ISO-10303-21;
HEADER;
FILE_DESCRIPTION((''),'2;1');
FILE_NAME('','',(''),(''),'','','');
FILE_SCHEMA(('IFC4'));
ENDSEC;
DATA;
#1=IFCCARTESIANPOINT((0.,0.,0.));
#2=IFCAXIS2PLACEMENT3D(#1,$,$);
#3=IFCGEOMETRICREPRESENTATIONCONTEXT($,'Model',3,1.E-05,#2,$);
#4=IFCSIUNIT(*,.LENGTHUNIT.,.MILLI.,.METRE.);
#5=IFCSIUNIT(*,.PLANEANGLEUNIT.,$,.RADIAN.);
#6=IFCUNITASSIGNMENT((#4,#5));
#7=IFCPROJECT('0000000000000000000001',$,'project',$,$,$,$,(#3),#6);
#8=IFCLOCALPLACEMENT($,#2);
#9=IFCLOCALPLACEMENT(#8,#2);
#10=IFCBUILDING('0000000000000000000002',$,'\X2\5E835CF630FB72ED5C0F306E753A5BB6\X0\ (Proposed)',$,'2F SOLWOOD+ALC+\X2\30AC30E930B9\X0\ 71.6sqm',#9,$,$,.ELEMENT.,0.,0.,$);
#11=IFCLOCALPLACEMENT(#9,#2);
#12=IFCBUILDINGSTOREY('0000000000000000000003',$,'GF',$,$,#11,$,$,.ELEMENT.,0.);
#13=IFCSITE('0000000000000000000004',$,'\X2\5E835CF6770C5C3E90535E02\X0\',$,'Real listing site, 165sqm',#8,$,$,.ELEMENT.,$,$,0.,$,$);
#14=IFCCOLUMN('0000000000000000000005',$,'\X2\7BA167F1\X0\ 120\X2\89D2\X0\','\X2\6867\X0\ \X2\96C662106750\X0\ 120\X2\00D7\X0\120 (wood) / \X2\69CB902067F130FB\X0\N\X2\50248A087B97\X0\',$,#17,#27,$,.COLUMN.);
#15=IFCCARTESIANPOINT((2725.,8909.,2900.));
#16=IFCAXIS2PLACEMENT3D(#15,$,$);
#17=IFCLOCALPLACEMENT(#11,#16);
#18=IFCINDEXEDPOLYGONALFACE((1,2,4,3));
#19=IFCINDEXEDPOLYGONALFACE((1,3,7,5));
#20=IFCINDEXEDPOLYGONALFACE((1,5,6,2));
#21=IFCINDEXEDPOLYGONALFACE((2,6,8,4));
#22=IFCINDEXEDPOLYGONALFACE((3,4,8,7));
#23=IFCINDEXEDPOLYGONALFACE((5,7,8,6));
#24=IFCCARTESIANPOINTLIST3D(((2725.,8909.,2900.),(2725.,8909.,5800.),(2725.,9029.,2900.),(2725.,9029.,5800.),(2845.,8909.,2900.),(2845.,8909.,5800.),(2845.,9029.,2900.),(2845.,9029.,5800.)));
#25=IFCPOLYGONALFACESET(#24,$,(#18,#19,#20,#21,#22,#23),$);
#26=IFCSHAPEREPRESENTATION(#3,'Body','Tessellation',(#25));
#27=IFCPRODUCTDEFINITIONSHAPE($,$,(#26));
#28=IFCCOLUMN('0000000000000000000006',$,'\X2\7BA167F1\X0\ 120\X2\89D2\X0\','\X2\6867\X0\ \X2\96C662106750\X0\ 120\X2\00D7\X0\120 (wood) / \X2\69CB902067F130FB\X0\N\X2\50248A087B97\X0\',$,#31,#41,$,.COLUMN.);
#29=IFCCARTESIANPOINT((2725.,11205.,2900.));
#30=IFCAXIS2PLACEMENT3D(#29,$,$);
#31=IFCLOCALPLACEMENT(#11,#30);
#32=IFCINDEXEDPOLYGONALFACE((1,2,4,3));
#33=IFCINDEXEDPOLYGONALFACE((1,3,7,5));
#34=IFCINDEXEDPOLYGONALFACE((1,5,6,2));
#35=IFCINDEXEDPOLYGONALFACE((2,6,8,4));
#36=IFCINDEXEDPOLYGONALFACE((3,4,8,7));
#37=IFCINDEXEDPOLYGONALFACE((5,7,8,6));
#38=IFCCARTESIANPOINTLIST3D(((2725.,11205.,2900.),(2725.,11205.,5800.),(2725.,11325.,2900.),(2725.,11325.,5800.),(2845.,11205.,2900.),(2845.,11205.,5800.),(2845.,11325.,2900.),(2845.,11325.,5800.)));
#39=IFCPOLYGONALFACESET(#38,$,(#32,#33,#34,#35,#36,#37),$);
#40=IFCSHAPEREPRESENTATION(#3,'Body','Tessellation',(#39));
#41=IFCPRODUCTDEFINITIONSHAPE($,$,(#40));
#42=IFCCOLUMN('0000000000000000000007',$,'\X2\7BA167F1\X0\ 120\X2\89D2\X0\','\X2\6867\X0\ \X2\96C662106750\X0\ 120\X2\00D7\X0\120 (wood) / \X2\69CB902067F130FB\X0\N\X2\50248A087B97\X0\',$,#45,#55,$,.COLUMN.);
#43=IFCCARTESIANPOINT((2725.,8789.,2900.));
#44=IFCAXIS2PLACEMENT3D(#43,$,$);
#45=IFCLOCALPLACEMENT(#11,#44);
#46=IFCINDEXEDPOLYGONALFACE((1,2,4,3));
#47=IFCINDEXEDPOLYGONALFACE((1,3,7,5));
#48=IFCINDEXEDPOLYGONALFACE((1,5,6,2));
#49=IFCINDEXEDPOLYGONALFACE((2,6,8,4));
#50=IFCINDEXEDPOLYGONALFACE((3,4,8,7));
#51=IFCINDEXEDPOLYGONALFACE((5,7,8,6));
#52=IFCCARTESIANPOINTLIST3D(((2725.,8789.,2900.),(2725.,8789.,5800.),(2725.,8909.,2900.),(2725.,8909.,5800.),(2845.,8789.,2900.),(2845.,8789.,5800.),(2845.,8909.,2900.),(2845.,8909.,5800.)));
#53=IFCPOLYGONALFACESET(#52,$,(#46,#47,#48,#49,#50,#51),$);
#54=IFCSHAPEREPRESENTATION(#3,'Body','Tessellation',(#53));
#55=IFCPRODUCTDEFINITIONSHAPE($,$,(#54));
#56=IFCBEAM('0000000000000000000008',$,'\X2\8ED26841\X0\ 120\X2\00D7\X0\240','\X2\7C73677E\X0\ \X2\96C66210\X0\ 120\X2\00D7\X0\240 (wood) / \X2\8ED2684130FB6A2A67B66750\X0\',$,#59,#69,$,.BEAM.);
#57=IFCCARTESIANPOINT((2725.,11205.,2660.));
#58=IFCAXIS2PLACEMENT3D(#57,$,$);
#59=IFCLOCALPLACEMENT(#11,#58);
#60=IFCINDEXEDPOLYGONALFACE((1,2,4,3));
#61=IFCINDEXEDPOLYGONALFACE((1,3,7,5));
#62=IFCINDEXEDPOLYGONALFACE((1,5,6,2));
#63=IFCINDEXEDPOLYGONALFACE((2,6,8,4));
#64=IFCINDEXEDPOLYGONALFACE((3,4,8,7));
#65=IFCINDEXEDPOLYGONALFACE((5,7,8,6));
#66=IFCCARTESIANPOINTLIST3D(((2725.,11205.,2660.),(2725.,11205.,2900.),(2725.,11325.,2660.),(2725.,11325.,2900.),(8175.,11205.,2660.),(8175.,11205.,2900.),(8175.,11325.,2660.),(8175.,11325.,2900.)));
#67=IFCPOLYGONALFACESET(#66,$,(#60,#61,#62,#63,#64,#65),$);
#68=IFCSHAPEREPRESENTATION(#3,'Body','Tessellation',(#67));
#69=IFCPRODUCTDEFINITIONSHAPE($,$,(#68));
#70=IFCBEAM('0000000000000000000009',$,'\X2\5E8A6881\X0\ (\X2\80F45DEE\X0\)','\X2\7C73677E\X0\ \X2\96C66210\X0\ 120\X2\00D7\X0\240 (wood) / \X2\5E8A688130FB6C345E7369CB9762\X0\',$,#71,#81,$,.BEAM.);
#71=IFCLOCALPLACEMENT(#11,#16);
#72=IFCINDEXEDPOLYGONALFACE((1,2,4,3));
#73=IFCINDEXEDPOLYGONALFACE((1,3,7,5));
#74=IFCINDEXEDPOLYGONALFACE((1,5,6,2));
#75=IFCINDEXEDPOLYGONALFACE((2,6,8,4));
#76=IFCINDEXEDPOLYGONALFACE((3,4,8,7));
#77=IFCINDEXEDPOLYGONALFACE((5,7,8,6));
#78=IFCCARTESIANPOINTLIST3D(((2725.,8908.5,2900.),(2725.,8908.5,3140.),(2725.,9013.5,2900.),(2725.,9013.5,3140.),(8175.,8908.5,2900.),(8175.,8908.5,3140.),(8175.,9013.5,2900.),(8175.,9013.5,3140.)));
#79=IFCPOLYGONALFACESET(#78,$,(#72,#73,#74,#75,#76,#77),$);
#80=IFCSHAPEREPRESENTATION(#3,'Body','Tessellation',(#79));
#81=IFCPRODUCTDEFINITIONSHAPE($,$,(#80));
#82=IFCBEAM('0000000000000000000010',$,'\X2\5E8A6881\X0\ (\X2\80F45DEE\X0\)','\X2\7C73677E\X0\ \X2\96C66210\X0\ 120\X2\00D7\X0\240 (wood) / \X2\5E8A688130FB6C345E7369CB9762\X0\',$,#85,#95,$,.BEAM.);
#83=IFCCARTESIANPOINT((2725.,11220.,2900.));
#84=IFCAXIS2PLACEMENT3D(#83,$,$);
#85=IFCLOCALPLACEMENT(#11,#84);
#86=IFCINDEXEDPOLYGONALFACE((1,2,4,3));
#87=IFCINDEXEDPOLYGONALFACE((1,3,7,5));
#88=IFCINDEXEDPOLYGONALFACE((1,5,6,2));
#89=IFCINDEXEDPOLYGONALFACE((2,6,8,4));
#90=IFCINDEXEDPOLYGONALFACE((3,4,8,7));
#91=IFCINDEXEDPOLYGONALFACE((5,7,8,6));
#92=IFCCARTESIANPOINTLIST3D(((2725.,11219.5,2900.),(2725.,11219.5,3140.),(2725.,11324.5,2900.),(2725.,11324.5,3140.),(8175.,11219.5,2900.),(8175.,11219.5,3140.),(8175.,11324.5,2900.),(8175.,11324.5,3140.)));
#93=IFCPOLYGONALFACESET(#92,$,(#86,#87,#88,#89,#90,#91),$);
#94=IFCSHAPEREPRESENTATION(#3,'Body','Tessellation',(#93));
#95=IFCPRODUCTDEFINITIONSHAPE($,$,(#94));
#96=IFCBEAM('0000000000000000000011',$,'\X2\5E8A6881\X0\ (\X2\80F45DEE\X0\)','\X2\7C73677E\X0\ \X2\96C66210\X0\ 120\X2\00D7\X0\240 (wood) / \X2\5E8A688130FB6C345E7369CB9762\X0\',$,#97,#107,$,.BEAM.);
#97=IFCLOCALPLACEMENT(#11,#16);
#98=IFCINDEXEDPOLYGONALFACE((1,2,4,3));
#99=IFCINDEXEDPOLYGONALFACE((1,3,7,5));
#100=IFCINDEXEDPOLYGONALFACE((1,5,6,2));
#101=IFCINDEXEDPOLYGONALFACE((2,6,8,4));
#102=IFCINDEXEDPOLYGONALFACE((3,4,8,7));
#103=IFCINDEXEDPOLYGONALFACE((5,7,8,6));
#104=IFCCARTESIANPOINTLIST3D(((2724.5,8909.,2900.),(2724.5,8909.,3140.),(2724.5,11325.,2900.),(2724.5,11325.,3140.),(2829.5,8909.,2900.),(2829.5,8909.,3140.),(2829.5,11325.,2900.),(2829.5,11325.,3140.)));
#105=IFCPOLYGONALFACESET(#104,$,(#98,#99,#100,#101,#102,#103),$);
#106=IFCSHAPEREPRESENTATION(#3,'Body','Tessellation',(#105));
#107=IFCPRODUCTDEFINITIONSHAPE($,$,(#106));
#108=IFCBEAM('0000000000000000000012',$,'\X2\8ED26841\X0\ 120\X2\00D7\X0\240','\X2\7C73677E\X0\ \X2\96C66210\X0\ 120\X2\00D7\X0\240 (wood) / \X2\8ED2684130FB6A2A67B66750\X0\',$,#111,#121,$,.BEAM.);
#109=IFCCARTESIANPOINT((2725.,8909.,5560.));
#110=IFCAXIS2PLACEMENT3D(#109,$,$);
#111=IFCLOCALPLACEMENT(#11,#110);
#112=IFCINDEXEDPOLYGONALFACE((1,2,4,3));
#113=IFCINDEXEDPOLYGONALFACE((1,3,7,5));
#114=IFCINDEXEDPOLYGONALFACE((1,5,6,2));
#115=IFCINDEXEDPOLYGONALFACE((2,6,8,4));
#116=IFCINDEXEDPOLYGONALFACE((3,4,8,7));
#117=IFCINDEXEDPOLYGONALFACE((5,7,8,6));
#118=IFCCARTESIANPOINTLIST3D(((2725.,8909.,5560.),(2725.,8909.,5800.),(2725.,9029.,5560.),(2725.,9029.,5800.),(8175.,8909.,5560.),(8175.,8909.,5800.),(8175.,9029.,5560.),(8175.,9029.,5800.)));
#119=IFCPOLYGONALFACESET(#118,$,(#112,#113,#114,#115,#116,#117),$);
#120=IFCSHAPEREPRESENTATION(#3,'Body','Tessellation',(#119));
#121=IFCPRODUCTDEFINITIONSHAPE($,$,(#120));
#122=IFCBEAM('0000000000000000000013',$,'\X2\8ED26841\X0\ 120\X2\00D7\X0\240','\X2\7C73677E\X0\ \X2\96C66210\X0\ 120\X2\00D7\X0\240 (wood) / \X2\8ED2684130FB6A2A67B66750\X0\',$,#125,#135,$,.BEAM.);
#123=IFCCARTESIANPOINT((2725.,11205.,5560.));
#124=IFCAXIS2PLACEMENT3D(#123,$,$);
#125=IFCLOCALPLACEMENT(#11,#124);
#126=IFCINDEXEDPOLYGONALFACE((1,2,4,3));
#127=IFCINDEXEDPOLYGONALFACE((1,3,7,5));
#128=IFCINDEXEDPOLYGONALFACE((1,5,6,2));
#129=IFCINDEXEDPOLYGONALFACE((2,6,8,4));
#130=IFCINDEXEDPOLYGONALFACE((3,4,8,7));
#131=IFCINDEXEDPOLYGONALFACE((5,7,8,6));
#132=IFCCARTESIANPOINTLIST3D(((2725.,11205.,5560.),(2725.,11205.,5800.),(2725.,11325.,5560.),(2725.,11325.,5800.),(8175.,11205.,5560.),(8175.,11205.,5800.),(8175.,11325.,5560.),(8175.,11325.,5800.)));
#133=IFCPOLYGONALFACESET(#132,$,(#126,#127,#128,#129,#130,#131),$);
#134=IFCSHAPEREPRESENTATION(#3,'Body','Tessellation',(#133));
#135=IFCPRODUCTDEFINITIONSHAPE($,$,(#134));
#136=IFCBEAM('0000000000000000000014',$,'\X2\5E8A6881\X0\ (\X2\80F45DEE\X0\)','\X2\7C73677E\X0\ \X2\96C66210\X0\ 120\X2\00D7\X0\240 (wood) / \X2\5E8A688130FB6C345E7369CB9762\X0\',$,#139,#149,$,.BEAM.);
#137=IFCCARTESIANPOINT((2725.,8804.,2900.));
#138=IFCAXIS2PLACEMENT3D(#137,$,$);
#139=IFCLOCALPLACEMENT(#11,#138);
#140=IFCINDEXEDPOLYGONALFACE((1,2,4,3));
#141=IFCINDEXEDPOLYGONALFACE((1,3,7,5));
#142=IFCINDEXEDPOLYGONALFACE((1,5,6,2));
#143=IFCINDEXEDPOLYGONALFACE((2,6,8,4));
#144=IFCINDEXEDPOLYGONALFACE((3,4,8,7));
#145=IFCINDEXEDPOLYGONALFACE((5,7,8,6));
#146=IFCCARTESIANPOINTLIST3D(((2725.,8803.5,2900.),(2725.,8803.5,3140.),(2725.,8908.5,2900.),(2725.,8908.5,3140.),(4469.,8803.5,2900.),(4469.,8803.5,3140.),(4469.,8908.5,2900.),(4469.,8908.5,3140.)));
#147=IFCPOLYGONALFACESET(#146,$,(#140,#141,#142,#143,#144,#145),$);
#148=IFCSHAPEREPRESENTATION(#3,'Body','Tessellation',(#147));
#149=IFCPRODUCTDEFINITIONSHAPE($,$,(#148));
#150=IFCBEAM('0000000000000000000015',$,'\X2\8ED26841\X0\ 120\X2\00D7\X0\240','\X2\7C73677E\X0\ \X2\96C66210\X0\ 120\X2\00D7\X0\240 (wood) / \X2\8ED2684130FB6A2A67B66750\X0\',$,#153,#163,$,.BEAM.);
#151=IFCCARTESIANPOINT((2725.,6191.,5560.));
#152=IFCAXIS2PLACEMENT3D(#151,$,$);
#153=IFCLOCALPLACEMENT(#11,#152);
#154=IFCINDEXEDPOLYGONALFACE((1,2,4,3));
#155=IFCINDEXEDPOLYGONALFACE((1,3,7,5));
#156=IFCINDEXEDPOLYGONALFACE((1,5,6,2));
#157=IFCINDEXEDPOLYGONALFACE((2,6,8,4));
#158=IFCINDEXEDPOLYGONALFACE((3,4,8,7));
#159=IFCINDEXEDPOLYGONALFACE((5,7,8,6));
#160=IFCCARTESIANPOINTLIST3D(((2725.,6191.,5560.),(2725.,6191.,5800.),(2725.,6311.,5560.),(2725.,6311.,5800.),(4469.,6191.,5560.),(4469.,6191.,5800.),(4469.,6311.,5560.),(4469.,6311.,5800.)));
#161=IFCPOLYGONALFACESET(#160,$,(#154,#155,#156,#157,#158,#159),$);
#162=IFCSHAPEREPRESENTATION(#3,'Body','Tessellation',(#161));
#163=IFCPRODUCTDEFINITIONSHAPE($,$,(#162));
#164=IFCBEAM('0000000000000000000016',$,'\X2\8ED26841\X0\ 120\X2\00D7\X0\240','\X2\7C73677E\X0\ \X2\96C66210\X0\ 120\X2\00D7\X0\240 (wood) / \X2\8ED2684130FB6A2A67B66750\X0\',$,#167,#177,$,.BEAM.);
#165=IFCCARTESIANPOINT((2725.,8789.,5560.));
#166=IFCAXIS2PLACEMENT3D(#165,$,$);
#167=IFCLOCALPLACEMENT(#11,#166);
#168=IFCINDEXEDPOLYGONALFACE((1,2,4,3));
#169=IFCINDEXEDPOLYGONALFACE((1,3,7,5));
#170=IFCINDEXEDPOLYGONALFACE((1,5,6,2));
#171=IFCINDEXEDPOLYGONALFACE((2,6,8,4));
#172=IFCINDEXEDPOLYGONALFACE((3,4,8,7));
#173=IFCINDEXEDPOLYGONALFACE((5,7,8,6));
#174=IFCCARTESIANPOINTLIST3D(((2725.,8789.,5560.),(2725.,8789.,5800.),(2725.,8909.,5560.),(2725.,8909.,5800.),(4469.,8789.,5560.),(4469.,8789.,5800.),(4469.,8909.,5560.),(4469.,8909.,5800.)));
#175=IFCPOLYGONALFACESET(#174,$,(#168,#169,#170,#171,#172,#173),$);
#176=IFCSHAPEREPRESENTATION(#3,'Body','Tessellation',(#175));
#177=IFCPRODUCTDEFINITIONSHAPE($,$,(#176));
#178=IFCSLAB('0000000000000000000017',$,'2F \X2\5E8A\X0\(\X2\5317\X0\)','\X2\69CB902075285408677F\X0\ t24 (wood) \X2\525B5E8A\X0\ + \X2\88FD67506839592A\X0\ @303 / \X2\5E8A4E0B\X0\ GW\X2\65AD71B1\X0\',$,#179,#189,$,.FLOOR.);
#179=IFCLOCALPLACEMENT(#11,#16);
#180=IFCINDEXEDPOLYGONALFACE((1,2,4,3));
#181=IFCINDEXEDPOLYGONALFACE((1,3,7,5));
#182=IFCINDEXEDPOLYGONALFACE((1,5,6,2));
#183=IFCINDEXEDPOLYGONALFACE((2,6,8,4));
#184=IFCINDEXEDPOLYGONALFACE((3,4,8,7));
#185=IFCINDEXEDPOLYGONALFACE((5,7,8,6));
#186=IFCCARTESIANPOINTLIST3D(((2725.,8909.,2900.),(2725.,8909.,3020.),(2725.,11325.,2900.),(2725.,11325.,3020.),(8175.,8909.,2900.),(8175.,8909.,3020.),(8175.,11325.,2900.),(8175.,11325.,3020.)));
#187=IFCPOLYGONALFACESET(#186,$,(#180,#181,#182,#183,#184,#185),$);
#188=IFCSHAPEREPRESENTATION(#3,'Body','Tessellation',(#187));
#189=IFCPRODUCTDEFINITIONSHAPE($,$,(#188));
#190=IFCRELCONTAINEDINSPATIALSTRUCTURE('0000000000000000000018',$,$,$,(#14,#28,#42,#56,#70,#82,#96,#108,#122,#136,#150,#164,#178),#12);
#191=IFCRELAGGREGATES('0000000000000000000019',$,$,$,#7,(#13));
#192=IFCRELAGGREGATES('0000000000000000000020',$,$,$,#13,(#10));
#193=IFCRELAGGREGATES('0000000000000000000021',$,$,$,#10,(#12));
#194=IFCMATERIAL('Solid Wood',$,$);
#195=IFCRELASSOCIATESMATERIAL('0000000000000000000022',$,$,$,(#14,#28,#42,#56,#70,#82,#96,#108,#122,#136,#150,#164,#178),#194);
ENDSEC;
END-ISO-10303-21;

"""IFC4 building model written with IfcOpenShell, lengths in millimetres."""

from ifc_helpers import new_model, si_unit, frame, frame_2d, origin, place, context, project, spatial, rectangle, extrude, material, element, save


model = new_model("IFC4")

# Units and contexts
model_context = context("Model", 3, precision=1e-05, world=origin())
ifc_project = project(units=[si_unit("LENGTHUNIT", "METRE", prefix="MILLI"), si_unit("PLANEANGLEUNIT", "RADIAN")], contexts=[model_context])

# Site, building, storey
site_placement = place(None, origin())
site = spatial("IfcSite", under=ifc_project, at=site_placement, Name="広島県尾道市", ObjectType="Real listing site, 165sqm", CompositionType="ELEMENT", RefElevation=0.0)
building_placement = place(site_placement, origin())
building = spatial("IfcBuilding", under=site, at=building_placement, Name="広島・狭小の町家 (Proposed)", ObjectType="2F SOLWOOD+ALC+ガラス 71.6sqm", CompositionType="ELEMENT", ElevationOfRefHeight=0.0, ElevationOfTerrain=0.0)
storey_placement = place(building_placement, origin())
storey = spatial("IfcBuildingStorey", under=building, at=storey_placement, Name="GF", CompositionType="ELEMENT", Elevation=0.0)

# Columns
ifc_material_1 = material(Name="Solid Wood")
column_1_placement = place(storey_placement, frame((2725.0, 8909.0, 2900.0)))
element("IfcColumn", 1, at=column_1_placement, inside=storey, material=ifc_material_1, Name="管柱 120角", Description="桧 集成材 120×120 (wood) / 構造柱・N値計算", PredefinedType="COLUMN", context=model_context, shape_type="SweptSolid", body=[
    extrude(rectangle(XDim=120.0, YDim=120.0, at=frame_2d((60.0, 60.0))), frame((2725.0, 8909.0, 2900.0)), (0.0, 0.0, 1.0), 2900.0),
])
column_2_placement = place(storey_placement, frame((2725.0, 11205.0, 2900.0)))
element("IfcColumn", 2, at=column_2_placement, inside=storey, material=ifc_material_1, Name="管柱 120角", Description="桧 集成材 120×120 (wood) / 構造柱・N値計算", PredefinedType="COLUMN", context=model_context, shape_type="SweptSolid", body=[
    extrude(rectangle(XDim=120.0, YDim=120.0, at=frame_2d((60.0, 60.0))), frame((2725.0, 11205.0, 2900.0)), (0.0, 0.0, 1.0), 2900.0),
])
column_3_placement = place(storey_placement, frame((2725.0, 8789.0, 2900.0)))
element("IfcColumn", 3, at=column_3_placement, inside=storey, material=ifc_material_1, Name="管柱 120角", Description="桧 集成材 120×120 (wood) / 構造柱・N値計算", PredefinedType="COLUMN", context=model_context, shape_type="SweptSolid", body=[
    extrude(rectangle(XDim=120.0, YDim=120.0, at=frame_2d((60.0, 60.0))), frame((2725.0, 8789.0, 2900.0)), (0.0, 0.0, 1.0), 2900.0),
])

# Beams
beam_1_placement = place(storey_placement, frame((2725.0, 11205.0, 2660.0)))
element("IfcBeam", 4, at=beam_1_placement, inside=storey, material=ifc_material_1, Name="軒桁 120×240", Description="米松 集成 120×240 (wood) / 軒桁・横架材", PredefinedType="BEAM", context=model_context, shape_type="SweptSolid", body=[
    extrude(rectangle(XDim=5450.0, YDim=120.0, at=frame_2d((2725.0, 60.0))), frame((2725.0, 11205.0, 2660.0)), (0.0, 0.0, 1.0), 240.0),
])
beam_2_placement = place(storey_placement, frame((2725.0, 8909.0, 2900.0)))
element("IfcBeam", 5, at=beam_2_placement, inside=storey, material=ifc_material_1, Name="床梁 (胴差)", Description="米松 集成 120×240 (wood) / 床梁・水平構面", PredefinedType="BEAM", context=model_context, shape_type="SweptSolid", body=[
    extrude(rectangle(XDim=5450.0, YDim=105.0, at=frame_2d((2725.0, 52.0))), frame((2725.0, 8909.0, 2900.0)), (0.0, 0.0, 1.0), 240.0),
])
beam_3_placement = place(storey_placement, frame((2725.0, 11220.0, 2900.0)))
element("IfcBeam", 6, at=beam_3_placement, inside=storey, material=ifc_material_1, Name="床梁 (胴差)", Description="米松 集成 120×240 (wood) / 床梁・水平構面", PredefinedType="BEAM", context=model_context, shape_type="SweptSolid", body=[
    extrude(rectangle(XDim=5450.0, YDim=105.0, at=frame_2d((2725.0, 52.0))), frame((2725.0, 11220.0, 2900.0)), (0.0, 0.0, 1.0), 240.0),
])
beam_4_placement = place(storey_placement, frame((2725.0, 8909.0, 2900.0)))
element("IfcBeam", 7, at=beam_4_placement, inside=storey, material=ifc_material_1, Name="床梁 (胴差)", Description="米松 集成 120×240 (wood) / 床梁・水平構面", PredefinedType="BEAM", context=model_context, shape_type="SweptSolid", body=[
    extrude(rectangle(XDim=105.0, YDim=2416.0, at=frame_2d((52.0, 1208.0))), frame((2725.0, 8909.0, 2900.0)), (0.0, 0.0, 1.0), 240.0),
])
beam_5_placement = place(storey_placement, frame((2725.0, 8909.0, 5560.0)))
element("IfcBeam", 8, at=beam_5_placement, inside=storey, material=ifc_material_1, Name="軒桁 120×240", Description="米松 集成 120×240 (wood) / 軒桁・横架材", PredefinedType="BEAM", context=model_context, shape_type="SweptSolid", body=[
    extrude(rectangle(XDim=5450.0, YDim=120.0, at=frame_2d((2725.0, 60.0))), frame((2725.0, 8909.0, 5560.0)), (0.0, 0.0, 1.0), 240.0),
])
beam_6_placement = place(storey_placement, frame((2725.0, 11205.0, 5560.0)))
element("IfcBeam", 9, at=beam_6_placement, inside=storey, material=ifc_material_1, Name="軒桁 120×240", Description="米松 集成 120×240 (wood) / 軒桁・横架材", PredefinedType="BEAM", context=model_context, shape_type="SweptSolid", body=[
    extrude(rectangle(XDim=5450.0, YDim=120.0, at=frame_2d((2725.0, 60.0))), frame((2725.0, 11205.0, 5560.0)), (0.0, 0.0, 1.0), 240.0),
])
beam_7_placement = place(storey_placement, frame((2725.0, 8804.0, 2900.0)))
element("IfcBeam", 10, at=beam_7_placement, inside=storey, material=ifc_material_1, Name="床梁 (胴差)", Description="米松 集成 120×240 (wood) / 床梁・水平構面", PredefinedType="BEAM", context=model_context, shape_type="SweptSolid", body=[
    extrude(rectangle(XDim=1744.0, YDim=105.0, at=frame_2d((872.0, 52.0))), frame((2725.0, 8804.0, 2900.0)), (0.0, 0.0, 1.0), 240.0),
])
beam_8_placement = place(storey_placement, frame((2725.0, 6191.0, 5560.0)))
element("IfcBeam", 11, at=beam_8_placement, inside=storey, material=ifc_material_1, Name="軒桁 120×240", Description="米松 集成 120×240 (wood) / 軒桁・横架材", PredefinedType="BEAM", context=model_context, shape_type="SweptSolid", body=[
    extrude(rectangle(XDim=1744.0, YDim=120.0, at=frame_2d((872.0, 60.0))), frame((2725.0, 6191.0, 5560.0)), (0.0, 0.0, 1.0), 240.0),
])
beam_9_placement = place(storey_placement, frame((2725.0, 8789.0, 5560.0)))
element("IfcBeam", 12, at=beam_9_placement, inside=storey, material=ifc_material_1, Name="軒桁 120×240", Description="米松 集成 120×240 (wood) / 軒桁・横架材", PredefinedType="BEAM", context=model_context, shape_type="SweptSolid", body=[
    extrude(rectangle(XDim=1744.0, YDim=120.0, at=frame_2d((872.0, 60.0))), frame((2725.0, 8789.0, 5560.0)), (0.0, 0.0, 1.0), 240.0),
])

# Slab
slab_placement = place(storey_placement, frame((2725.0, 8909.0, 2900.0)))
element("IfcSlab", 13, at=slab_placement, inside=storey, material=ifc_material_1, Name="2F 床(北)", Description="構造用合板 t24 (wood) 剛床 + 製材根太 @303 / 床下 GW断熱", PredefinedType="FLOOR", context=model_context, shape_type="SweptSolid", body=[
    extrude(rectangle(XDim=5450.0, YDim=2416.0, at=frame_2d((2725.0, 1208.0))), frame((2725.0, 8909.0, 2900.0)), (0.0, 0.0, 1.0), 120.0),
])

save(model, "model.ifc")
